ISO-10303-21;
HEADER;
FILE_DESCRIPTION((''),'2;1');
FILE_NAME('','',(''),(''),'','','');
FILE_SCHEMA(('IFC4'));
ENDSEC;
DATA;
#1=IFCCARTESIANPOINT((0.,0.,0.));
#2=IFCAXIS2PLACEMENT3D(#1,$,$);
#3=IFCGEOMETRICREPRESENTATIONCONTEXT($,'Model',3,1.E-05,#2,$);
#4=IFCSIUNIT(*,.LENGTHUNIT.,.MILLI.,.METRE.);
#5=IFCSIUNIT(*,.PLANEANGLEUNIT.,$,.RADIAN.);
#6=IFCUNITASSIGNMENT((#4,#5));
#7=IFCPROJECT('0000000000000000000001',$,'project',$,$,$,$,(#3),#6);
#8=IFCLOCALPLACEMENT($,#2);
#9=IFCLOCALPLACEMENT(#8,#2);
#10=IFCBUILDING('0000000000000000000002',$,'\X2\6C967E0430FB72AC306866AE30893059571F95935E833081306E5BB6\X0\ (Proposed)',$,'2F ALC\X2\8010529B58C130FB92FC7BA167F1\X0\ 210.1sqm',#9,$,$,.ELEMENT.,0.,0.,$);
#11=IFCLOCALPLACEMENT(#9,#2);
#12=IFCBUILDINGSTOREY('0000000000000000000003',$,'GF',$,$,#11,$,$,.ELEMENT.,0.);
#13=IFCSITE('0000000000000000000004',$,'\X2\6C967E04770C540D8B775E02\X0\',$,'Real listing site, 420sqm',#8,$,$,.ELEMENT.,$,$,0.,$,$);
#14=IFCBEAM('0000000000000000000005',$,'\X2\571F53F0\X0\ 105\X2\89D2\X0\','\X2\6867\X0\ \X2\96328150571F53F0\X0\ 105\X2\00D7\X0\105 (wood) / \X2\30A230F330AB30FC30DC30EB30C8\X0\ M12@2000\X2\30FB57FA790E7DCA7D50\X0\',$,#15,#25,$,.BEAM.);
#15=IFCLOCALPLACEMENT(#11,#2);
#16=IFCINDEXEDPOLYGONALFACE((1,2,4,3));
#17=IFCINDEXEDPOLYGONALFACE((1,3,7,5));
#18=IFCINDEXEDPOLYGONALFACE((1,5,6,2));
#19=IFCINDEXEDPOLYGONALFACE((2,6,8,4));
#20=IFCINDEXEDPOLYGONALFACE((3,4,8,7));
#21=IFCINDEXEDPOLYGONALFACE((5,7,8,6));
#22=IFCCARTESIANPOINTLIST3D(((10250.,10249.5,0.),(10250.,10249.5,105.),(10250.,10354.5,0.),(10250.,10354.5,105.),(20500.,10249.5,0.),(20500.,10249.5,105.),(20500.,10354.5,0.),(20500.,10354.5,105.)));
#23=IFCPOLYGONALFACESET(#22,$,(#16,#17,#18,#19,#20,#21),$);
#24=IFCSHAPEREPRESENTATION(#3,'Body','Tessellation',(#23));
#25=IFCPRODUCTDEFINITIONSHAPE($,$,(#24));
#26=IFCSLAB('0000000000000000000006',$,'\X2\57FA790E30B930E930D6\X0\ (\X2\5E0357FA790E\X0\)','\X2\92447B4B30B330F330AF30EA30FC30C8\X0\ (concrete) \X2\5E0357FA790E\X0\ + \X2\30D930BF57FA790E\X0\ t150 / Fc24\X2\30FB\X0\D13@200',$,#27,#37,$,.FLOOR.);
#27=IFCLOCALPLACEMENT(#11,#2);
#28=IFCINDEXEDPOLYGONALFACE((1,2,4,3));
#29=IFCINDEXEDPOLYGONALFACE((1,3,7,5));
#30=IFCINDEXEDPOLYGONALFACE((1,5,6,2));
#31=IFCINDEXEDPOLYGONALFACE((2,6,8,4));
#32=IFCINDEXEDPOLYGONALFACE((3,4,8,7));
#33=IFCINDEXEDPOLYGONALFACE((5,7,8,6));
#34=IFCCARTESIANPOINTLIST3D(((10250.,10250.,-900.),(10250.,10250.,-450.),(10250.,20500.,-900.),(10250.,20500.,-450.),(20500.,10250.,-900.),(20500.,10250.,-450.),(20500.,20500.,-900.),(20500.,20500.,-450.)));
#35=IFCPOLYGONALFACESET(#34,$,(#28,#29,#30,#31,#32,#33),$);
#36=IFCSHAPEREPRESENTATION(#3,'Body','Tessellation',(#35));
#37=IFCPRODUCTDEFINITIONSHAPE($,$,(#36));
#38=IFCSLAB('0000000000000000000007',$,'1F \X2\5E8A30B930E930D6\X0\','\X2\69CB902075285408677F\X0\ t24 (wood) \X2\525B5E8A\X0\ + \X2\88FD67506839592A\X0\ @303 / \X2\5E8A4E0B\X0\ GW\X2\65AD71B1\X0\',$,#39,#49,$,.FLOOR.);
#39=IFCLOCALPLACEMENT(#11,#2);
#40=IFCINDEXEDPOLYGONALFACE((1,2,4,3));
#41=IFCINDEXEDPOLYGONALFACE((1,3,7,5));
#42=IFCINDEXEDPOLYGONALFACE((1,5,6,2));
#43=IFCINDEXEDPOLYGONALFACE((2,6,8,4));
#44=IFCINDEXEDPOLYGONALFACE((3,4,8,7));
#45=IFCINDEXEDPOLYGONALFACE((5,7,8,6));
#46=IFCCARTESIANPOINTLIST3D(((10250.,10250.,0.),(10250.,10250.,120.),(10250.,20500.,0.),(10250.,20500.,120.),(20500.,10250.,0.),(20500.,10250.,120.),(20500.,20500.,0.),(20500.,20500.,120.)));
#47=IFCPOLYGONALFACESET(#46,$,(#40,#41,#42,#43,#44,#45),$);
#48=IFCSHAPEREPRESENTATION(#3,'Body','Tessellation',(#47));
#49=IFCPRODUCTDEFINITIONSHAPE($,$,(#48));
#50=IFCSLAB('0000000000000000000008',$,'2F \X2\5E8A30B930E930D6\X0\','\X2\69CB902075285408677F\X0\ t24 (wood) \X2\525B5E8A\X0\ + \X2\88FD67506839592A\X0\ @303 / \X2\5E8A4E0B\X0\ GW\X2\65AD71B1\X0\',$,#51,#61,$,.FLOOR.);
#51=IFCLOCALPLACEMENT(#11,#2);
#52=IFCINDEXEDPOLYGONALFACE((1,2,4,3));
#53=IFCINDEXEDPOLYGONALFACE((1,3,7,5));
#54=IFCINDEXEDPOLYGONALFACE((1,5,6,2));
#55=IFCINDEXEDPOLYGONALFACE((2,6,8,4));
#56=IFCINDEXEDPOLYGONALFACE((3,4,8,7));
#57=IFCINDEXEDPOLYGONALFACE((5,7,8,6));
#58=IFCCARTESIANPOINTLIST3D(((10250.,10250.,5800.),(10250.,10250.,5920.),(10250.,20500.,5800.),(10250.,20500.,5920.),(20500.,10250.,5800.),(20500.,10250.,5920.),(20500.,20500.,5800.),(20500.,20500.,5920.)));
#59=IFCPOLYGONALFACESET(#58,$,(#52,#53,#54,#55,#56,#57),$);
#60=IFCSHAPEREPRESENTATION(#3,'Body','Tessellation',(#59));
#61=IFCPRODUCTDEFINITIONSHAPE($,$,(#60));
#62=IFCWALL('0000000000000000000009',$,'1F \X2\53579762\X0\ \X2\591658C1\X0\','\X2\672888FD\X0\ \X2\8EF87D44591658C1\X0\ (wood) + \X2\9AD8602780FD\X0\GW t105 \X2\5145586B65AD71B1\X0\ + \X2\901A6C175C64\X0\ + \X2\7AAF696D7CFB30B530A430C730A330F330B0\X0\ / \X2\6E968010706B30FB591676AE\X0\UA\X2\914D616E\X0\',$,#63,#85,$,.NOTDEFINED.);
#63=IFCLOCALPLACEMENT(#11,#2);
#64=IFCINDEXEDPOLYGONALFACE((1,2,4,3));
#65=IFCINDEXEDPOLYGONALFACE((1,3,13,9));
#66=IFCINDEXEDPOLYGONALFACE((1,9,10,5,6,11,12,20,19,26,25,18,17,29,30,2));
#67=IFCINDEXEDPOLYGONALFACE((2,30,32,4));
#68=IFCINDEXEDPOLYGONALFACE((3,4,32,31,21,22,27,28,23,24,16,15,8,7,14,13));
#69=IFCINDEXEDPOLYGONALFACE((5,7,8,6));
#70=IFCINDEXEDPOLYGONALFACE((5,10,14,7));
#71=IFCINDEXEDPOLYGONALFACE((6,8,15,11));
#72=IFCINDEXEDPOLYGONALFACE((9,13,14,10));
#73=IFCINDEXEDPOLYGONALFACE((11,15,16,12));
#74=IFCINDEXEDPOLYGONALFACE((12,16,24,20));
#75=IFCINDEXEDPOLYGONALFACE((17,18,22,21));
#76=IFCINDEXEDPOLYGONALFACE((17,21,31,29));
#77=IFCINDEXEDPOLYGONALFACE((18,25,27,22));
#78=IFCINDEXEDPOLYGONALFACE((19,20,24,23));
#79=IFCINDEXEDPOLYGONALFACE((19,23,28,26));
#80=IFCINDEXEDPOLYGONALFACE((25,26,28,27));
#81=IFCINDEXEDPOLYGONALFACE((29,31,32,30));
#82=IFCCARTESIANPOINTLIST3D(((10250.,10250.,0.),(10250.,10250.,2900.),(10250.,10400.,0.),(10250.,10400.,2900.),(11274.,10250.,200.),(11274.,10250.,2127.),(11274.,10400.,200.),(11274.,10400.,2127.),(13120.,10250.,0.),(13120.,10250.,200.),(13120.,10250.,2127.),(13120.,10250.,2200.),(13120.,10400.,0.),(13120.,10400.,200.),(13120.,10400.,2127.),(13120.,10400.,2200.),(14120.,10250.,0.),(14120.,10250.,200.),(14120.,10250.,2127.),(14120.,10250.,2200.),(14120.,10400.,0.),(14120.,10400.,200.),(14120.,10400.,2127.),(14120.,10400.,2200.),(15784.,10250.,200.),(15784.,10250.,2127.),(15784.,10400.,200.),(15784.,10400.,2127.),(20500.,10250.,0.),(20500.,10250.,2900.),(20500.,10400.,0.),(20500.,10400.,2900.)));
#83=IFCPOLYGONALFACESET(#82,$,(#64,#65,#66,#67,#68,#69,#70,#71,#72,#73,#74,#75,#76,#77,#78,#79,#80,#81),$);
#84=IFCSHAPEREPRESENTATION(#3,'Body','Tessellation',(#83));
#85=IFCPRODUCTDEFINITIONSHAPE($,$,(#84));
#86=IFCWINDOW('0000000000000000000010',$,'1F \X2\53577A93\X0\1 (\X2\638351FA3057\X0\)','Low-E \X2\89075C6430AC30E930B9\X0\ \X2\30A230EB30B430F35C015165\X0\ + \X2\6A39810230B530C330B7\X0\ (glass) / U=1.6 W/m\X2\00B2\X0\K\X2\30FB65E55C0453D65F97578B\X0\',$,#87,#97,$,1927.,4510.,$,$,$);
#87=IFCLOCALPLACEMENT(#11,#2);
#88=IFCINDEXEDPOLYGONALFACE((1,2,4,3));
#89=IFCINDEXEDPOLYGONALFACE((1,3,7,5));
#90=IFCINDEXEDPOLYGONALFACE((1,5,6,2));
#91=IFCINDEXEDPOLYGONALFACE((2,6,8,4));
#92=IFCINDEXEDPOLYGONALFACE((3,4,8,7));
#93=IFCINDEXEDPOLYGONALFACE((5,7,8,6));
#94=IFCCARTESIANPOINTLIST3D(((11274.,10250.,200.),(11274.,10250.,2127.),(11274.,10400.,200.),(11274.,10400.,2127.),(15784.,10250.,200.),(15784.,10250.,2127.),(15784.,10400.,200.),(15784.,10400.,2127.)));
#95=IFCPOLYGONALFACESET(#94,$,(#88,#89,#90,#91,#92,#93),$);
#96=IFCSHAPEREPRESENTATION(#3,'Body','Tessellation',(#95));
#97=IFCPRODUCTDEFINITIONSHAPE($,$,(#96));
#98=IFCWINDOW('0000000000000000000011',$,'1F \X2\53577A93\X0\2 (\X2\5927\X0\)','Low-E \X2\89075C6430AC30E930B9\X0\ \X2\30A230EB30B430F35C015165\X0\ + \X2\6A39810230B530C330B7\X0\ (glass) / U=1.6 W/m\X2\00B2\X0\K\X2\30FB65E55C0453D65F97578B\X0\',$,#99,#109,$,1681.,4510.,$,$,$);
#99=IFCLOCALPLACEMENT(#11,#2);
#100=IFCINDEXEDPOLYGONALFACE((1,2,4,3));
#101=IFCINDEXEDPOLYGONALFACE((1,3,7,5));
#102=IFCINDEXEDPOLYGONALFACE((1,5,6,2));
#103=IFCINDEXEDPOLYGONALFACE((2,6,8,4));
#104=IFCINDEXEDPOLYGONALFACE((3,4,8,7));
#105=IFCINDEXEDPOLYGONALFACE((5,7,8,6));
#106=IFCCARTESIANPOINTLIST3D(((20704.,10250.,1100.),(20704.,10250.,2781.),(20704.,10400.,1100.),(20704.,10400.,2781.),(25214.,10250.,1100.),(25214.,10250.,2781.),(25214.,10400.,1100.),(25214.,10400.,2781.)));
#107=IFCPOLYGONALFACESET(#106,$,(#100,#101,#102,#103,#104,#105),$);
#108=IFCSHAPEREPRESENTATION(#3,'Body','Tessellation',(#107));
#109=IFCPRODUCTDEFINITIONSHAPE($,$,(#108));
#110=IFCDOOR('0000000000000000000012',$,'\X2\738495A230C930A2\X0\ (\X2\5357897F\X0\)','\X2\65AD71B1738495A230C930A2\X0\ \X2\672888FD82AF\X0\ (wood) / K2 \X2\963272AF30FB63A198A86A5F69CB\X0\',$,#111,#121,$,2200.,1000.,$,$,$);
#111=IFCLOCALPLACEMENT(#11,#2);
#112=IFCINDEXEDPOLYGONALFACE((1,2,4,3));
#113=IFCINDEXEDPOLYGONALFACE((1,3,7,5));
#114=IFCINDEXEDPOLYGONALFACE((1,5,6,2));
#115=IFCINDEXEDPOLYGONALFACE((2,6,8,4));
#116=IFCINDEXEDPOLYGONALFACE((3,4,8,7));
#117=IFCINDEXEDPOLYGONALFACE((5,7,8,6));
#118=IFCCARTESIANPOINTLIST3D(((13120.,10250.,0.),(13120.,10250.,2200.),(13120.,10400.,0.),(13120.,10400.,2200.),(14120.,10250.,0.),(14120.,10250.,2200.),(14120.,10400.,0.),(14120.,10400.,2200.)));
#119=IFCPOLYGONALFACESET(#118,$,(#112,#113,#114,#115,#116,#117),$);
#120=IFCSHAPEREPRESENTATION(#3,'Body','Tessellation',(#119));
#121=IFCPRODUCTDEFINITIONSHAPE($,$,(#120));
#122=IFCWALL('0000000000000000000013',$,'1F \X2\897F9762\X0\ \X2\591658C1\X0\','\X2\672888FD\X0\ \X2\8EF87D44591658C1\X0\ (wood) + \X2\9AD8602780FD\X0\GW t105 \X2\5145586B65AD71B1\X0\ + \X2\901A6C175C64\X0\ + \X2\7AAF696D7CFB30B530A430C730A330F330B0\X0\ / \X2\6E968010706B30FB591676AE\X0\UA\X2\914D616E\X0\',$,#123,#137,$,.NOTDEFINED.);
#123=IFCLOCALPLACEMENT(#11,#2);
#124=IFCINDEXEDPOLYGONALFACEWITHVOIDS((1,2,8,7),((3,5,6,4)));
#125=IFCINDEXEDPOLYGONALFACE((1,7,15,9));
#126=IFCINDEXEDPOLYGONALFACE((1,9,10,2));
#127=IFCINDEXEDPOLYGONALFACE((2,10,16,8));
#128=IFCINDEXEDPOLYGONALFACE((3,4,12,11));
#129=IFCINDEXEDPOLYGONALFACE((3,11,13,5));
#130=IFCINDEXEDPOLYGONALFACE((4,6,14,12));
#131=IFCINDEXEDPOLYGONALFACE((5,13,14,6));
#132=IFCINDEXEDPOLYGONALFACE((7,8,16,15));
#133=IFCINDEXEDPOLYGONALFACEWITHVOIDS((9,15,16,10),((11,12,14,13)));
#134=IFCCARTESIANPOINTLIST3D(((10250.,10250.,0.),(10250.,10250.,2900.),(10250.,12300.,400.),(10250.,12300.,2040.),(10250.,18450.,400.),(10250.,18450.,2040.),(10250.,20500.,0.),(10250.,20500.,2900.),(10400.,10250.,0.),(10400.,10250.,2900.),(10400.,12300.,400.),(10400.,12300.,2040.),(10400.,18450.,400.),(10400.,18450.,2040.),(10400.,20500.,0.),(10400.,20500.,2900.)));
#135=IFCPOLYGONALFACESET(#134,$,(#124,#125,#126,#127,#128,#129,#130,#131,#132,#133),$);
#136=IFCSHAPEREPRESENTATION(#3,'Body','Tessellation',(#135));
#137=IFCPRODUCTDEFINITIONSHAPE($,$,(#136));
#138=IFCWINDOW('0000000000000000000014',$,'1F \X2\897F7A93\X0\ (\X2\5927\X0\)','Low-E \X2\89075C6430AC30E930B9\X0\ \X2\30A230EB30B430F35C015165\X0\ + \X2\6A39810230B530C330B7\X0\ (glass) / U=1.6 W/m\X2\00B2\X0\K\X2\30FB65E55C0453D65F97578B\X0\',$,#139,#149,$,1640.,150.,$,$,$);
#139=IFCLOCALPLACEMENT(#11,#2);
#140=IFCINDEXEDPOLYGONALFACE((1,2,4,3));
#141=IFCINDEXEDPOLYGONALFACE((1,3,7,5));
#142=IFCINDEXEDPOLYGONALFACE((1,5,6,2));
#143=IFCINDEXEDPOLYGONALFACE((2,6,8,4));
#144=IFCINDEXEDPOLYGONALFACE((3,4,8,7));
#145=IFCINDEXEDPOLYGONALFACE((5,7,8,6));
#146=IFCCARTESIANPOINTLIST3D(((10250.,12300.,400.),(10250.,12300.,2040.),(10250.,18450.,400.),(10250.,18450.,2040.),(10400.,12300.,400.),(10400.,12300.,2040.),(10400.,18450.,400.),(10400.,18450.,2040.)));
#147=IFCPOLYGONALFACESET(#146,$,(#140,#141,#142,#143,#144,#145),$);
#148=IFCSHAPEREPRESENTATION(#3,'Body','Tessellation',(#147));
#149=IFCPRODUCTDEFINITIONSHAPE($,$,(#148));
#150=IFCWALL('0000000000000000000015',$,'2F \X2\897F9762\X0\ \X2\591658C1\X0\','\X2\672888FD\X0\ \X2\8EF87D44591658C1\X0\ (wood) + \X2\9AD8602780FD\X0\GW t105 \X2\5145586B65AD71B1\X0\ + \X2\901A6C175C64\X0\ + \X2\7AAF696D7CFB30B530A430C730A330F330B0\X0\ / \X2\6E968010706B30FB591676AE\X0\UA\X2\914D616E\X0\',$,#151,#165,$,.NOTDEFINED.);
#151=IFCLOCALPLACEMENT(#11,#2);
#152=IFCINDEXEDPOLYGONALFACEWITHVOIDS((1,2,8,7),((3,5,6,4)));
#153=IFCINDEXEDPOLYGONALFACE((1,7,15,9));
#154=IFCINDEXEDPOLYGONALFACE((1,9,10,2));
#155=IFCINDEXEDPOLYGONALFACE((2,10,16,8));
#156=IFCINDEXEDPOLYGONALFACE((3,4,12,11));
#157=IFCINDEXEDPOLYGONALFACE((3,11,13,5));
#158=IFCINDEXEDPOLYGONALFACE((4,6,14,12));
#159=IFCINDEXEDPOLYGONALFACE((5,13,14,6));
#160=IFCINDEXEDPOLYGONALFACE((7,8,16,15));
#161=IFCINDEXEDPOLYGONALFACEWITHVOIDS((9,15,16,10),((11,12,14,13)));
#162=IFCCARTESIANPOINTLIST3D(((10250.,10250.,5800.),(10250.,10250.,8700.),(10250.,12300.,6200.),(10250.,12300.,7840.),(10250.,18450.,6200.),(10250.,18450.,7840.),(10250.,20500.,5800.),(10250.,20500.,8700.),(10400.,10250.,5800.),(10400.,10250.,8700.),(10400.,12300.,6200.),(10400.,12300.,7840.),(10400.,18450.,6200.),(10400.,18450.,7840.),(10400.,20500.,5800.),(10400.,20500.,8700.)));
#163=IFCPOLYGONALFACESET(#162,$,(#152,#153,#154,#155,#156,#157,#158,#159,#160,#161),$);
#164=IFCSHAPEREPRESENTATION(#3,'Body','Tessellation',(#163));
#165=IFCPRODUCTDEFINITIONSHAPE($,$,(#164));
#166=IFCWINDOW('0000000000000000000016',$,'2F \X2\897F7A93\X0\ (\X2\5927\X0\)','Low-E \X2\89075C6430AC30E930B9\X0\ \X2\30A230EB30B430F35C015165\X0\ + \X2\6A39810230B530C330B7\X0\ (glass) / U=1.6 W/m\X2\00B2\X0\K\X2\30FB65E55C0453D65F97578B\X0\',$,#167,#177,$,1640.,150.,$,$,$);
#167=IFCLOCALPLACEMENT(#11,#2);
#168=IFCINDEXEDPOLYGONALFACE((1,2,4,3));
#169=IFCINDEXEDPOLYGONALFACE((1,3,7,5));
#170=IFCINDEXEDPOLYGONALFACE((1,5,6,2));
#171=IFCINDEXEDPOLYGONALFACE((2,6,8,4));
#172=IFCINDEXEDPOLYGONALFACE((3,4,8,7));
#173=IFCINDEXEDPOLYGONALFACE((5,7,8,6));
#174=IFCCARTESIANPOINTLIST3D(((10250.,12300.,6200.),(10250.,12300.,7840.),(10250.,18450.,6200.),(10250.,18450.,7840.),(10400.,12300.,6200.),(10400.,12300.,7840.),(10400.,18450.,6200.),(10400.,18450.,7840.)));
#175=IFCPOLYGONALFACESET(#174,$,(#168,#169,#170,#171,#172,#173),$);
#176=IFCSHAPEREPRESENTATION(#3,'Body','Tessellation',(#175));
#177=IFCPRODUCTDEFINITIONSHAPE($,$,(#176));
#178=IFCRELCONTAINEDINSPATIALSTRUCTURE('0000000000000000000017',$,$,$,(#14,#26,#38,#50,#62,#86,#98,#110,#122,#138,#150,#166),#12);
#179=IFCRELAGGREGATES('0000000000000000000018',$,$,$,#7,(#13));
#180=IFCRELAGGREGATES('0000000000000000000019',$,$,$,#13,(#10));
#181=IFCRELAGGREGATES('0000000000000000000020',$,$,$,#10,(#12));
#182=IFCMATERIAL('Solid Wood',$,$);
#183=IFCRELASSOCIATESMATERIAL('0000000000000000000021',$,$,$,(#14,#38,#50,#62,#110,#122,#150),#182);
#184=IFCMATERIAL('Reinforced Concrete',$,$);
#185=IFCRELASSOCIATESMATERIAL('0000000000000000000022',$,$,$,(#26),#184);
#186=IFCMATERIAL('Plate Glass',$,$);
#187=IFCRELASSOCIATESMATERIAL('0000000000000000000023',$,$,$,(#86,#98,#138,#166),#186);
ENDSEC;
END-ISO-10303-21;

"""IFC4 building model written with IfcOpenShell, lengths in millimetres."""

from ifc_helpers import new_model, si_unit, frame, frame_2d, origin, place, context, project, spatial, rectangle, extrude, material, element, fill, save


model = new_model("IFC4")

# Units and contexts
model_context = context("Model", 3, precision=1e-05, world=origin())
ifc_project = project(units=[si_unit("LENGTHUNIT", "METRE", prefix="MILLI"), si_unit("PLANEANGLEUNIT", "RADIAN")], contexts=[model_context])

# Site, building, storey
site_placement = place(None, origin())
site = spatial("IfcSite", under=ifc_project, at=site_placement, Name="沖縄県名護市", ObjectType="Real listing site, 420sqm", CompositionType="ELEMENT", RefElevation=0.0)
building_placement = place(site_placement, origin())
building = spatial("IfcBuilding", under=site, at=building_placement, Name="沖縄・犬と暮らす土間広めの家 (Proposed)", ObjectType="2F ALC耐力壁・鋼管柱 210.1sqm", CompositionType="ELEMENT", ElevationOfRefHeight=0.0, ElevationOfTerrain=0.0)
storey_placement = place(building_placement, origin())
storey = spatial("IfcBuildingStorey", under=building, at=storey_placement, Name="GF", CompositionType="ELEMENT", Elevation=0.0)

# Shared definitions
ifc_material_1 = material(Name="Solid Wood")

# Beam
beam_placement = place(storey_placement, frame((5125.0, 5125.0, 0.0)))
element("IfcBeam", 1, at=beam_placement, inside=storey, material=ifc_material_1, Name="土台 105角", Description="桧 防腐土台 105×105 (wood) / アンカーボルト M12@2000・基礎緊結", PredefinedType="BEAM", context=model_context, shape_type="SweptSolid", body=[
    extrude(rectangle(XDim=10250.0, YDim=105.0, at=frame_2d((5125.0, 52.0))), frame((5125.0, 5125.0, 0.0)), (0.0, 0.0, 1.0), 105.0),
])

# Slabs
ifc_material_2 = material(Name="Reinforced Concrete")
slab_1_placement = place(storey_placement, frame((5125.0, 5125.0, -450.0)))
element("IfcSlab", 2, at=slab_1_placement, inside=storey, material=ifc_material_2, Name="基礎スラブ (布基礎)", Description="鉄筋コンクリート (concrete) 布基礎 + ベタ基礎 t150 / Fc24・D13@200", PredefinedType="FLOOR", context=model_context, shape_type="SweptSolid", body=[
    extrude(rectangle(XDim=10250.0, YDim=10250.0, at=frame_2d((5125.0, 5125.0))), frame((5125.0, 5125.0, -450.0)), (0.0, 0.0, 1.0), 450.0),
])
slab_2_placement = place(storey_placement, frame((5125.0, 5125.0, 0.0)))
element("IfcSlab", 3, at=slab_2_placement, inside=storey, material=ifc_material_1, Name="1F 床スラブ", Description="構造用合板 t24 (wood) 剛床 + 製材根太 @303 / 床下 GW断熱", PredefinedType="FLOOR", context=model_context, shape_type="SweptSolid", body=[
    extrude(rectangle(XDim=10250.0, YDim=10250.0, at=frame_2d((5125.0, 5125.0))), frame((5125.0, 5125.0, 0.0)), (0.0, 0.0, 1.0), 120.0),
])
slab_3_placement = place(storey_placement, frame((5125.0, 5125.0, 2900.0)))
element("IfcSlab", 4, at=slab_3_placement, inside=storey, material=ifc_material_1, Name="2F 床スラブ", Description="構造用合板 t24 (wood) 剛床 + 製材根太 @303 / 床下 GW断熱", PredefinedType="FLOOR", context=model_context, shape_type="SweptSolid", body=[
    extrude(rectangle(XDim=10250.0, YDim=10250.0, at=frame_2d((5125.0, 5125.0))), frame((5125.0, 5125.0, 2900.0)), (0.0, 0.0, 1.0), 120.0),
])

# Wall, openings, windows, door
wall_1_placement = place(storey_placement, frame((5125.0, 5125.0, 0.0)))
wall_1 = element("IfcWall", 5, at=wall_1_placement, inside=storey, material=ifc_material_1, Name="1F 南面 外壁", Description="木製 軸組外壁 (wood) + 高性能GW t105 充填断熱 + 通気層 + 窯業系サイディング / 準耐火・外皮UA配慮", PredefinedType="NOTDEFINED", context=model_context, shape_type="SweptSolid", body=[
    extrude(rectangle(XDim=10250.0, YDim=150.0, at=frame_2d((5125.0, 75.0))), frame((5125.0, 5125.0, 0.0)), (0.0, 0.0, 1.0), 2900.0),
])
opening_1_placement = place(storey_placement, frame((5637.0, 5125.0, 100.0)))
opening_1 = element("IfcOpeningElement", 6, at=opening_1_placement, cuts=wall_1, PredefinedType="NOTDEFINED", context=model_context, shape_type="SweptSolid", body=[
    extrude(rectangle(XDim=4510.0, YDim=150.0, at=frame_2d((2255.0, 75.0))), frame((5637.0, 5125.0, 100.0)), (0.0, 0.0, 1.0), 1927.0),
])
opening_2_placement = place(storey_placement, frame((10352.0, 5125.0, 550.0)))
opening_2 = element("IfcOpeningElement", 7, at=opening_2_placement, cuts=wall_1, PredefinedType="NOTDEFINED", context=model_context, shape_type="SweptSolid", body=[
    extrude(rectangle(XDim=4510.0, YDim=150.0, at=frame_2d((2255.0, 75.0))), frame((10352.0, 5125.0, 550.0)), (0.0, 0.0, 1.0), 1681.0),
])
opening_3_placement = place(storey_placement, frame((6560.0, 5125.0, 0.0)))
opening_3 = element("IfcOpeningElement", 8, at=opening_3_placement, cuts=wall_1, PredefinedType="NOTDEFINED", context=model_context, shape_type="SweptSolid", body=[
    extrude(rectangle(XDim=1000.0, YDim=150.0, at=frame_2d((500.0, 75.0))), frame((6560.0, 5125.0, 0.0)), (0.0, 0.0, 1.0), 2200.0),
])
ifc_material_3 = material(Name="Plate Glass")
window_1_placement = place(storey_placement, frame((5637.0, 5125.0, 100.0)))
window_1 = element("IfcWindow", 9, at=window_1_placement, inside=storey, material=ifc_material_3, Name="1F 南窓1 (掃出し)", Description="Low-E 複層ガラス アルゴン封入 + 樹脂サッシ (glass) / U=1.6 W/m²K・日射取得型", OverallHeight=1927.0, OverallWidth=4510.0, context=model_context, shape_type="SweptSolid", body=[
    extrude(rectangle(XDim=4510.0, YDim=150.0, at=frame_2d((2255.0, 75.0))), frame((5637.0, 5125.0, 100.0)), (0.0, 0.0, 1.0), 1927.0),
])
fill(opening_1, window_1)
window_2_placement = place(storey_placement, frame((10352.0, 5125.0, 550.0)))
window_2 = element("IfcWindow", 10, at=window_2_placement, inside=storey, material=ifc_material_3, Name="1F 南窓2 (大)", Description="Low-E 複層ガラス アルゴン封入 + 樹脂サッシ (glass) / U=1.6 W/m²K・日射取得型", OverallHeight=1681.0, OverallWidth=4510.0, context=model_context, shape_type="SweptSolid", body=[
    extrude(rectangle(XDim=4510.0, YDim=150.0, at=frame_2d((2255.0, 75.0))), frame((10352.0, 5125.0, 550.0)), (0.0, 0.0, 1.0), 1681.0),
])
fill(opening_2, window_2)
door_placement = place(storey_placement, frame((6560.0, 5125.0, 0.0)))
door = element("IfcDoor", 11, at=door_placement, inside=storey, material=ifc_material_1, Name="玄関ドア (南西)", Description="断熱玄関ドア 木製芯 (wood) / K2 防犯・採風機構", OverallHeight=2200.0, OverallWidth=1000.0, context=model_context, shape_type="SweptSolid", body=[
    extrude(rectangle(XDim=1000.0, YDim=150.0, at=frame_2d((500.0, 75.0))), frame((6560.0, 5125.0, 0.0)), (0.0, 0.0, 1.0), 2200.0),
])
fill(opening_3, door)

# Wall, opening, window
wall_2_placement = place(storey_placement, frame((5125.0, 5125.0, 0.0)))
wall_2 = element("IfcWall", 12, at=wall_2_placement, inside=storey, material=ifc_material_1, Name="1F 西面 外壁", Description="木製 軸組外壁 (wood) + 高性能GW t105 充填断熱 + 通気層 + 窯業系サイディング / 準耐火・外皮UA配慮", PredefinedType="NOTDEFINED", context=model_context, shape_type="SweptSolid", body=[
    extrude(rectangle(XDim=150.0, YDim=10250.0, at=frame_2d((75.0, 5125.0))), frame((5125.0, 5125.0, 0.0)), (0.0, 0.0, 1.0), 2900.0),
])
opening_4_placement = place(storey_placement, frame((5125.0, 6150.0, 200.0)))
opening_4 = element("IfcOpeningElement", 13, at=opening_4_placement, cuts=wall_2, PredefinedType="NOTDEFINED", context=model_context, shape_type="SweptSolid", body=[
    extrude(rectangle(XDim=150.0, YDim=6150.0, at=frame_2d((75.0, 3075.0))), frame((5125.0, 6150.0, 200.0)), (0.0, 0.0, 1.0), 1640.0),
])
window_3_placement = place(storey_placement, frame((5125.0, 6150.0, 200.0)))
window_3 = element("IfcWindow", 14, at=window_3_placement, inside=storey, material=ifc_material_3, Name="1F 西窓 (大)", Description="Low-E 複層ガラス アルゴン封入 + 樹脂サッシ (glass) / U=1.6 W/m²K・日射取得型", OverallHeight=1640.0, OverallWidth=150.0, context=model_context, shape_type="SweptSolid", body=[
    extrude(rectangle(XDim=150.0, YDim=6150.0, at=frame_2d((75.0, 3075.0))), frame((5125.0, 6150.0, 200.0)), (0.0, 0.0, 1.0), 1640.0),
])
fill(opening_4, window_3)

# Wall, opening, window
wall_3_placement = place(storey_placement, frame((5125.0, 5125.0, 2900.0)))
wall_3 = element("IfcWall", 15, at=wall_3_placement, inside=storey, material=ifc_material_1, Name="2F 西面 外壁", Description="木製 軸組外壁 (wood) + 高性能GW t105 充填断熱 + 通気層 + 窯業系サイディング / 準耐火・外皮UA配慮", PredefinedType="NOTDEFINED", context=model_context, shape_type="SweptSolid", body=[
    extrude(rectangle(XDim=150.0, YDim=10250.0, at=frame_2d((75.0, 5125.0))), frame((5125.0, 5125.0, 2900.0)), (0.0, 0.0, 1.0), 2900.0),
])
opening_5_placement = place(storey_placement, frame((5125.0, 6150.0, 3100.0)))
opening_5 = element("IfcOpeningElement", 16, at=opening_5_placement, cuts=wall_3, PredefinedType="NOTDEFINED", context=model_context, shape_type="SweptSolid", body=[
    extrude(rectangle(XDim=150.0, YDim=6150.0, at=frame_2d((75.0, 3075.0))), frame((5125.0, 6150.0, 3100.0)), (0.0, 0.0, 1.0), 1640.0),
])
window_4_placement = place(storey_placement, frame((5125.0, 6150.0, 3100.0)))
window_4 = element("IfcWindow", 17, at=window_4_placement, inside=storey, material=ifc_material_3, Name="2F 西窓 (大)", Description="Low-E 複層ガラス アルゴン封入 + 樹脂サッシ (glass) / U=1.6 W/m²K・日射取得型", OverallHeight=1640.0, OverallWidth=150.0, context=model_context, shape_type="SweptSolid", body=[
    extrude(rectangle(XDim=150.0, YDim=6150.0, at=frame_2d((75.0, 3075.0))), frame((5125.0, 6150.0, 3100.0)), (0.0, 0.0, 1.0), 1640.0),
])
fill(opening_5, window_4)

save(model, "model.ifc")
